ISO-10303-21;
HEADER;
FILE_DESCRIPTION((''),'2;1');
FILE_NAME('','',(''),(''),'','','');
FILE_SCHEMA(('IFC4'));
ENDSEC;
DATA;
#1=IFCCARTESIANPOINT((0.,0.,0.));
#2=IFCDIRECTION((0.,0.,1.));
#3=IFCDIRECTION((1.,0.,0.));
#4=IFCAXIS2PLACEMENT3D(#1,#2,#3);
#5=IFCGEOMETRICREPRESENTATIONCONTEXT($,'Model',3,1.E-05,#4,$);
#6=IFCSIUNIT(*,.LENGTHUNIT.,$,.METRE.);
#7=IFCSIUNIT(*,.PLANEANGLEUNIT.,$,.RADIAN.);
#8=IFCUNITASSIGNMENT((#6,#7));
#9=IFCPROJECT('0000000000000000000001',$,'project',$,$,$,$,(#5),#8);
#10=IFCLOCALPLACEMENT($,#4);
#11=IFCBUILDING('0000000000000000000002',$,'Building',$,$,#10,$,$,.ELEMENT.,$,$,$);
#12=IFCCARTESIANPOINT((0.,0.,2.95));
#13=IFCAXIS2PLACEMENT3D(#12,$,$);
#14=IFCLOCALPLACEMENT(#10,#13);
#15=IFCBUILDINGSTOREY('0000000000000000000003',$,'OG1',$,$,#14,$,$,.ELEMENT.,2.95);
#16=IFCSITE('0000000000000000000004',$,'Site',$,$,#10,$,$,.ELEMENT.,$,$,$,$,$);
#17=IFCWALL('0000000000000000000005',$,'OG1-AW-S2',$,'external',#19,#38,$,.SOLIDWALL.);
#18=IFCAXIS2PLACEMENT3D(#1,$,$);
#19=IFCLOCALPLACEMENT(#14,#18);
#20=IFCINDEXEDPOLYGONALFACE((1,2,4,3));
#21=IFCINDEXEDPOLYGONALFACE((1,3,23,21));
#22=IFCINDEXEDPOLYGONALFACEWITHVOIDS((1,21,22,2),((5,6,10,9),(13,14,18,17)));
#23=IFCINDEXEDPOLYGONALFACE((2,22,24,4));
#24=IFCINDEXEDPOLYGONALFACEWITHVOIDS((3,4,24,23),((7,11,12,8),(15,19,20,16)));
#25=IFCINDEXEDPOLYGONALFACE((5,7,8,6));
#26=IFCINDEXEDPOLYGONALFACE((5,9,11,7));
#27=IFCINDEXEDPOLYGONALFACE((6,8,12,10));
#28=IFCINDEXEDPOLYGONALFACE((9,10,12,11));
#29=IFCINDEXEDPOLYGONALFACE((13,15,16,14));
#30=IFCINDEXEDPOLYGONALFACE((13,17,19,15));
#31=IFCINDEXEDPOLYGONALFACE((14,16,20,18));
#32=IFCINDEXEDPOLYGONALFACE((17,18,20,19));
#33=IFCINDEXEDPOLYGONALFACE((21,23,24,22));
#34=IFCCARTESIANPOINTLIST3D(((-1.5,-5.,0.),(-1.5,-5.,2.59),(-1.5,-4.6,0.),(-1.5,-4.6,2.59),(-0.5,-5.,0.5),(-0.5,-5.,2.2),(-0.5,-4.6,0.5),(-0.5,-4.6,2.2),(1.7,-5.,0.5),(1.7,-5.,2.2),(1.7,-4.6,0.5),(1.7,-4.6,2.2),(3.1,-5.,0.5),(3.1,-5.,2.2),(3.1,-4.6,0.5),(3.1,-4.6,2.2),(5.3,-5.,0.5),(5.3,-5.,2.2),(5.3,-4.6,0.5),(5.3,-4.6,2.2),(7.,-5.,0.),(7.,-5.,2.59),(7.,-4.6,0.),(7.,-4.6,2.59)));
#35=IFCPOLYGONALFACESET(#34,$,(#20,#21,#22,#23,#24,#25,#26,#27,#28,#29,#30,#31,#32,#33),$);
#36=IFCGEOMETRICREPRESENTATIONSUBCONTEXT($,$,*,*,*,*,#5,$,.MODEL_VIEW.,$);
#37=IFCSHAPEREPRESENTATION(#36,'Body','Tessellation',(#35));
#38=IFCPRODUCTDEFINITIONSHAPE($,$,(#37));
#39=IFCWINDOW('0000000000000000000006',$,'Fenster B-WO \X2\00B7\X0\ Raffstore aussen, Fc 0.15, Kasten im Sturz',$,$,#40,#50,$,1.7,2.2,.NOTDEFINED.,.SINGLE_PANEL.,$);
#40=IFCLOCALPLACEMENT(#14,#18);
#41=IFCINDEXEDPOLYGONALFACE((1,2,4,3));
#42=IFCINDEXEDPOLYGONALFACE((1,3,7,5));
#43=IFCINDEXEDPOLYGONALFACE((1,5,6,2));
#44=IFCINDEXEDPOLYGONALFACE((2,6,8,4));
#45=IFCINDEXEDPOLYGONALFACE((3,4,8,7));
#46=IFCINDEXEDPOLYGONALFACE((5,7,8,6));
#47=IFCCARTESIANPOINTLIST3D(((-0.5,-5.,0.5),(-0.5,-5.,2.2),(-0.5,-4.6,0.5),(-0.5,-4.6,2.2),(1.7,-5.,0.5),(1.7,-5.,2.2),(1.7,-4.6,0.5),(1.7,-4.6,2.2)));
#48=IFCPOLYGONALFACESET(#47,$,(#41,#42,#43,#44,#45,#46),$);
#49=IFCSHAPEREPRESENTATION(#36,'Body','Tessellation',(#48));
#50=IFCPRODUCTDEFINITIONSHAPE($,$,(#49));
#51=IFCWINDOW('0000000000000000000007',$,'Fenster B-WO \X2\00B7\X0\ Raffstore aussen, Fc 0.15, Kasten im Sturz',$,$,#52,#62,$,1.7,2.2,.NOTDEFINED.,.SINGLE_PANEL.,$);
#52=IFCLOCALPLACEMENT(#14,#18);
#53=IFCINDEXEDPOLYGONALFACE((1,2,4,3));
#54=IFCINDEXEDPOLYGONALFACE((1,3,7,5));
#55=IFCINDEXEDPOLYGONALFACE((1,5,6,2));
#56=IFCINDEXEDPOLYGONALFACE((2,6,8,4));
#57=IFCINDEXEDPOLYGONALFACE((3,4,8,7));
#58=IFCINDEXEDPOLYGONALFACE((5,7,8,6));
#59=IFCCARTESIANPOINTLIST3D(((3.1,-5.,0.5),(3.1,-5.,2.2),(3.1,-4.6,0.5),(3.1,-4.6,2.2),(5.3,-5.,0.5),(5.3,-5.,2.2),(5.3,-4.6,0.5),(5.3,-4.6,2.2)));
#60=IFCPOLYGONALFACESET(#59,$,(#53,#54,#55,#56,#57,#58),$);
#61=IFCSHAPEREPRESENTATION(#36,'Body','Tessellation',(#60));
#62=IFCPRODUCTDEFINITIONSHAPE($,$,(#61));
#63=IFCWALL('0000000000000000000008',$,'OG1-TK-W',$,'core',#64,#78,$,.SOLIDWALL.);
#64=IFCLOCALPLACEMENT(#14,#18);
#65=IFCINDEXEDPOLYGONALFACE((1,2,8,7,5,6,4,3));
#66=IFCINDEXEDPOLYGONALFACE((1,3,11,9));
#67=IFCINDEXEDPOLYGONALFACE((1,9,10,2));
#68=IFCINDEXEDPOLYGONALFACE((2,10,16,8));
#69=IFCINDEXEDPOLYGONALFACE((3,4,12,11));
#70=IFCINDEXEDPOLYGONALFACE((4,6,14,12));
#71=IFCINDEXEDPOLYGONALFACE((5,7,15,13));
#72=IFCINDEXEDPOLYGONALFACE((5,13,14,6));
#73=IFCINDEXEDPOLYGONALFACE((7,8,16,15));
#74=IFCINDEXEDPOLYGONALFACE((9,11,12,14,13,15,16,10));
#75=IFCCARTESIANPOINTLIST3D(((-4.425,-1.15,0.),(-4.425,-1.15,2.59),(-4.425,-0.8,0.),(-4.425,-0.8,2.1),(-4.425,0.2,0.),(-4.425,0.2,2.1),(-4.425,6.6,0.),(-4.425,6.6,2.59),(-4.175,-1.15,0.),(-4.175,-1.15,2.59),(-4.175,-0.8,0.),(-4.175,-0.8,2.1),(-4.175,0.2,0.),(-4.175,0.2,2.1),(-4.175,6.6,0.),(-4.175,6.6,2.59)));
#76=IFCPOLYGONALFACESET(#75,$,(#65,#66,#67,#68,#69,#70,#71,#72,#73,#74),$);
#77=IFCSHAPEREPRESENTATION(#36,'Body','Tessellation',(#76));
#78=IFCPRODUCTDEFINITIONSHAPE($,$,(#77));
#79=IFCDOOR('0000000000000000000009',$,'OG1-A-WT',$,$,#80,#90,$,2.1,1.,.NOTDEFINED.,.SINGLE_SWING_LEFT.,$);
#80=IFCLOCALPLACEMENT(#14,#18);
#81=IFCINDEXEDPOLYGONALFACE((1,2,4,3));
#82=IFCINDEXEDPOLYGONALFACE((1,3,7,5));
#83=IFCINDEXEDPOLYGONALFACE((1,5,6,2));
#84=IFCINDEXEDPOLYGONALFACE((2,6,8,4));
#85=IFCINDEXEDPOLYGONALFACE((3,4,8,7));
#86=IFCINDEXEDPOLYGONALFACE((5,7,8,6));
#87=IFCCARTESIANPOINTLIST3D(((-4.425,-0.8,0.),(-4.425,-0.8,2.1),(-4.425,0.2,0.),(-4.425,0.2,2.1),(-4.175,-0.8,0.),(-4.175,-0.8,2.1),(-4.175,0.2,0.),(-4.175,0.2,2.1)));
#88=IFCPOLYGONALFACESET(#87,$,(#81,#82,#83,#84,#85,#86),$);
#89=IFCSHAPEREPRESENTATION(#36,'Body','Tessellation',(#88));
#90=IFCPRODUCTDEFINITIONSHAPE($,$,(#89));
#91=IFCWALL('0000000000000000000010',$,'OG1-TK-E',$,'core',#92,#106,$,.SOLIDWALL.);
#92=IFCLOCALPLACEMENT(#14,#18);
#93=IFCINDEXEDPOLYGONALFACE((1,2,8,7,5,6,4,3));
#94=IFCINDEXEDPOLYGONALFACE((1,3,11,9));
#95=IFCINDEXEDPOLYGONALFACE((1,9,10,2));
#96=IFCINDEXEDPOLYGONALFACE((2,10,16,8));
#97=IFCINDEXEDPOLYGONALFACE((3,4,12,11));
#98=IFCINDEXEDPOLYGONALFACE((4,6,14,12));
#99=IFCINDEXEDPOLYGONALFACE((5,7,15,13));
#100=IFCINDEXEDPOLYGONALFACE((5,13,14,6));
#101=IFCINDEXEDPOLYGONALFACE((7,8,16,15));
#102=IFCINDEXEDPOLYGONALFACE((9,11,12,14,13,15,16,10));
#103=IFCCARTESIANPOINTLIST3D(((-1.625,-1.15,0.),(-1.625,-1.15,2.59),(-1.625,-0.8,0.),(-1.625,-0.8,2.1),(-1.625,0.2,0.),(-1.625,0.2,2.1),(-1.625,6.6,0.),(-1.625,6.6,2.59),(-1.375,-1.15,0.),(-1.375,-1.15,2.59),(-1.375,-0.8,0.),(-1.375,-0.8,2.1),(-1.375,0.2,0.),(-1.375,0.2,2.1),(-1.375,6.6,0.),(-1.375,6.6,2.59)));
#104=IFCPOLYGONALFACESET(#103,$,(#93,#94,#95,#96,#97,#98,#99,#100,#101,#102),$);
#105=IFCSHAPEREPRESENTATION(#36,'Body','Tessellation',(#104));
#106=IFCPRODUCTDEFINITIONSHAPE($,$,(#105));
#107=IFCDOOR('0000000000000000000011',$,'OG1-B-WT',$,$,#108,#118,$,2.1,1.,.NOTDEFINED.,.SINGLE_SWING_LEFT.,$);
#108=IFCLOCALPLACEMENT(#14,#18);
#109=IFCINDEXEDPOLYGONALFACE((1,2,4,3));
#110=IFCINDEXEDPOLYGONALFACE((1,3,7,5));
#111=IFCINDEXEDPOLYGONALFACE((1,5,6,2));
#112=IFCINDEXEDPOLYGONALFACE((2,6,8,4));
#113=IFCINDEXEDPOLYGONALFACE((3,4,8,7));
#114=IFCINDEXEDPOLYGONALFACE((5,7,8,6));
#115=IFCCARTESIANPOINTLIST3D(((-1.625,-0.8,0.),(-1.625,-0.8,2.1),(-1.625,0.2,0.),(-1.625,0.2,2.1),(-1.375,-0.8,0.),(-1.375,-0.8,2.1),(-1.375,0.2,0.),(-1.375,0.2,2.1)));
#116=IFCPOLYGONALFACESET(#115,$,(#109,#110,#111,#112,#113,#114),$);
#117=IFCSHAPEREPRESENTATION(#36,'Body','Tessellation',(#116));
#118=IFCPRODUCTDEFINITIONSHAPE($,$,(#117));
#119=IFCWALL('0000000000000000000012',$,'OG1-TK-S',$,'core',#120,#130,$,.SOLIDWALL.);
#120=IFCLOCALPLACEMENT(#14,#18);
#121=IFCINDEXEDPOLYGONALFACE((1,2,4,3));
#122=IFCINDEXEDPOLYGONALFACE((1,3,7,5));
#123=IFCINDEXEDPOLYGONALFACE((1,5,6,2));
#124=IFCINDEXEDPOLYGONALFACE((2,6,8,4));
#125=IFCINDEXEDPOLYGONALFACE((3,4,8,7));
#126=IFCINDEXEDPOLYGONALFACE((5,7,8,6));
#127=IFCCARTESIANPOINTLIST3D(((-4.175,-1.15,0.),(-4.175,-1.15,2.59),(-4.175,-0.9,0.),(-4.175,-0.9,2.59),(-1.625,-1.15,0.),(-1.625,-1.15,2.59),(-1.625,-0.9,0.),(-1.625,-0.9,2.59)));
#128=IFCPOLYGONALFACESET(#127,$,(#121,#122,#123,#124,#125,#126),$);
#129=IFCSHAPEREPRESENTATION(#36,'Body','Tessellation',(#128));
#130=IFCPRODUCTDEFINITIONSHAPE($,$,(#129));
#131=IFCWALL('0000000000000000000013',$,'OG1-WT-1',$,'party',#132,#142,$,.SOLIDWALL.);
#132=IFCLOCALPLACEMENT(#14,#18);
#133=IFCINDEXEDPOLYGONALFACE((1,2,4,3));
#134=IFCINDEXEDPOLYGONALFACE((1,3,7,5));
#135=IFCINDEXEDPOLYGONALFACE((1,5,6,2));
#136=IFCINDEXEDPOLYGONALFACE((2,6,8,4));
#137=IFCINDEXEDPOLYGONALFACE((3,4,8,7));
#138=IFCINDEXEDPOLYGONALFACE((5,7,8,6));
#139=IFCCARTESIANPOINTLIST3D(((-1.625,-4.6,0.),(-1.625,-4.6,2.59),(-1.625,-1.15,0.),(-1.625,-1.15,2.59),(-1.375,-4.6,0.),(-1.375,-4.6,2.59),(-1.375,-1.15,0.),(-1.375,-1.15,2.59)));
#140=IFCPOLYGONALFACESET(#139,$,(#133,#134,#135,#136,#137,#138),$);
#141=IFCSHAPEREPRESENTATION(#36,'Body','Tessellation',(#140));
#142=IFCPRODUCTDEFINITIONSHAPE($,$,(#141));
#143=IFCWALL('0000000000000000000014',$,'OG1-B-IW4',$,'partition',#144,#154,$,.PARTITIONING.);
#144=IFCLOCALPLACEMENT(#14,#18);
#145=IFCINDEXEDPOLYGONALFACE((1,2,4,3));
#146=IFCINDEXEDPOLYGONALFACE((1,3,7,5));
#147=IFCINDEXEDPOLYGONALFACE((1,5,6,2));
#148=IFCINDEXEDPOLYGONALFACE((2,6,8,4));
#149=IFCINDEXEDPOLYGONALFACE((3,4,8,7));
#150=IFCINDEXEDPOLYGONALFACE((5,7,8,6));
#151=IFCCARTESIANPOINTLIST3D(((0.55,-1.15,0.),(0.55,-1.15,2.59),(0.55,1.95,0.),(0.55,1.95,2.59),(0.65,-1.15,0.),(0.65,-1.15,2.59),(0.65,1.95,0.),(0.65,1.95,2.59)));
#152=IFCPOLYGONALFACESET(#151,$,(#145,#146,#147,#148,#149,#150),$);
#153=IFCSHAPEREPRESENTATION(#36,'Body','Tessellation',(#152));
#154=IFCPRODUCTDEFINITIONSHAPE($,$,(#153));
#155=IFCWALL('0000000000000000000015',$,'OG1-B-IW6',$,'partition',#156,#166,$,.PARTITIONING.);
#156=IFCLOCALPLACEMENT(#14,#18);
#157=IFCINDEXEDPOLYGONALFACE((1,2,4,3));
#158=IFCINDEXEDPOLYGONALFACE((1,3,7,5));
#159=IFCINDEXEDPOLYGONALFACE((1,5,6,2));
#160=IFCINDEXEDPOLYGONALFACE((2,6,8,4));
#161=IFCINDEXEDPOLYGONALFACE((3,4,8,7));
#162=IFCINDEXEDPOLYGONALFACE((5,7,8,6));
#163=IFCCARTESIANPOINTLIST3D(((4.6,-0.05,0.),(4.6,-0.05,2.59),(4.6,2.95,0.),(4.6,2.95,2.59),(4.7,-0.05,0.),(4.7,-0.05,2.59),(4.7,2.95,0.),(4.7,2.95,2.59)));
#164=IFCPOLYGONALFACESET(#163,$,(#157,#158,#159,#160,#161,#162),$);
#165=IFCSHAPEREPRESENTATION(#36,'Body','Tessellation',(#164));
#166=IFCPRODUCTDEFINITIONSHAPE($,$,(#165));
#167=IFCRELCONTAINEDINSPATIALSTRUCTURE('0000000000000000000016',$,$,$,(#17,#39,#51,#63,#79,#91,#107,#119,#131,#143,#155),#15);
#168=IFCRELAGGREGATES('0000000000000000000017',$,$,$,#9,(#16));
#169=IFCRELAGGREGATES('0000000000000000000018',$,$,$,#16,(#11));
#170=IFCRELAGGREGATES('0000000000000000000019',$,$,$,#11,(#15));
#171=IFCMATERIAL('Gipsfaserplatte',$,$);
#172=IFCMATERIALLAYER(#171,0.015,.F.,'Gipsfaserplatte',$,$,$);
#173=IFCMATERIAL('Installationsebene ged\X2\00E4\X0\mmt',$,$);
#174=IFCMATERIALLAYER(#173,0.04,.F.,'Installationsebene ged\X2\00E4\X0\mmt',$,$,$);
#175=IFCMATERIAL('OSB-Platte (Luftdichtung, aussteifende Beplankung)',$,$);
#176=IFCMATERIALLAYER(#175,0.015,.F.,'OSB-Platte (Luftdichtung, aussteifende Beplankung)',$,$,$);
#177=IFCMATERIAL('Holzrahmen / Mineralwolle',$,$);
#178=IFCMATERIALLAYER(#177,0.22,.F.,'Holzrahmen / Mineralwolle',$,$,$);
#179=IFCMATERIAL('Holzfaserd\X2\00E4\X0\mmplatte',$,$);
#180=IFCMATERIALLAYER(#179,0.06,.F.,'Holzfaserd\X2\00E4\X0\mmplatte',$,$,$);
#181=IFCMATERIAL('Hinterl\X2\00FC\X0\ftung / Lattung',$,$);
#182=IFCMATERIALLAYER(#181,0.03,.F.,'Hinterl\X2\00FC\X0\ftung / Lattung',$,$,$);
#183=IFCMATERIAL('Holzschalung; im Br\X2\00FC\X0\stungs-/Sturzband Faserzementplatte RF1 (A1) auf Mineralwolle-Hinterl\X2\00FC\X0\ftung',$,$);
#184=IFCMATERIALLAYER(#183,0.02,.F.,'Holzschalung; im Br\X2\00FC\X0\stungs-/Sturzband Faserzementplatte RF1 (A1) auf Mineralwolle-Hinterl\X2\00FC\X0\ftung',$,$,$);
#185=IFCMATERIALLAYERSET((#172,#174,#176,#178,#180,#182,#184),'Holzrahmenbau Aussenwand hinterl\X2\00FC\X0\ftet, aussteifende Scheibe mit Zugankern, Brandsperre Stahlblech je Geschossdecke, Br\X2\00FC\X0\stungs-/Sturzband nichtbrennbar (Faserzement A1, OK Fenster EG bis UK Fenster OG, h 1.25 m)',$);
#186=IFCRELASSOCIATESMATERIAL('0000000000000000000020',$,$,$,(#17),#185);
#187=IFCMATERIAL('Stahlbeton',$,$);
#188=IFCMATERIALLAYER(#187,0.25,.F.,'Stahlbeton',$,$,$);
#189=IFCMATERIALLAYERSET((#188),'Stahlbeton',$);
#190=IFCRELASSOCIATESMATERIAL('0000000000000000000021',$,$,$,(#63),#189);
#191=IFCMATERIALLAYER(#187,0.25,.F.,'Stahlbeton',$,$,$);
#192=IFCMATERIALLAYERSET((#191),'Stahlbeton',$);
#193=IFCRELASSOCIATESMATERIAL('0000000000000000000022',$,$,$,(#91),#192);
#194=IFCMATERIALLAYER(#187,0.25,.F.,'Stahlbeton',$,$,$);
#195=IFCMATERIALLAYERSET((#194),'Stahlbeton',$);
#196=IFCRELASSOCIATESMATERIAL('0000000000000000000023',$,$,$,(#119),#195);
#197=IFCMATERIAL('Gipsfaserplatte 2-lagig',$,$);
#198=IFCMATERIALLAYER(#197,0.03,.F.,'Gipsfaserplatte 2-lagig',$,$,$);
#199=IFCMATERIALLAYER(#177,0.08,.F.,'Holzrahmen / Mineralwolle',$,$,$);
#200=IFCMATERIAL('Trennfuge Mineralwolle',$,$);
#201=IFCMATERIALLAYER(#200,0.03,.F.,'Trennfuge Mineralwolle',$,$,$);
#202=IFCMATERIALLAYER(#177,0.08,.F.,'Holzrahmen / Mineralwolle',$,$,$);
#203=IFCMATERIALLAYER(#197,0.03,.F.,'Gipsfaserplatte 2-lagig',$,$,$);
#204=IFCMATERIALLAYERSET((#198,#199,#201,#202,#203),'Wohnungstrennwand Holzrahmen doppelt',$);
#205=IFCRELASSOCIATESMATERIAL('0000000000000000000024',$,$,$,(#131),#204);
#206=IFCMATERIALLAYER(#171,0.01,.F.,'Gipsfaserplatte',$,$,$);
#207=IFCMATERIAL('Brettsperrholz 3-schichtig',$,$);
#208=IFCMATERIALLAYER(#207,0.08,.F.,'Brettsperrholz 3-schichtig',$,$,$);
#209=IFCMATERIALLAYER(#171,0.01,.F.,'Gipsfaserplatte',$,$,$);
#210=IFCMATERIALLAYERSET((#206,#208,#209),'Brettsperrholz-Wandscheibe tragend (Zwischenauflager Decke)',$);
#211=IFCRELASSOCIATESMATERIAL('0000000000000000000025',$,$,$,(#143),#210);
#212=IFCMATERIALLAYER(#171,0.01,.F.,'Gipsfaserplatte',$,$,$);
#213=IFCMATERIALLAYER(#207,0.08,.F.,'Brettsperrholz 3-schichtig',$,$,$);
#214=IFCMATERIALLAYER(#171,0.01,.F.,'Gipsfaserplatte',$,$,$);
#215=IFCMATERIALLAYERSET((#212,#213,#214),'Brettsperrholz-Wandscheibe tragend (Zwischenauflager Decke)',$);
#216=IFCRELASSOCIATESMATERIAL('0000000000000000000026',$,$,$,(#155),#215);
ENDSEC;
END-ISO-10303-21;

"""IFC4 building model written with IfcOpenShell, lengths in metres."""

from ifc_helpers import new_model, si_unit, frame, frame_2d, origin, origin_with_axes, place, context, subcontext, project, spatial, rectangle, extrude, material, layer, layer_set, element, fill, save


model = new_model("IFC4")

# Units and contexts
model_context = context("Model", 3, precision=1e-05, world=origin_with_axes())
sub_context = subcontext(model_context, None, None, "MODEL_VIEW")
ifc_project = project(units=[si_unit("LENGTHUNIT", "METRE"), si_unit("PLANEANGLEUNIT", "RADIAN")], contexts=[model_context])

# Site, building, storey
placement = place(None, origin_with_axes())
site = spatial("IfcSite", under=ifc_project, at=placement, Name="Site", CompositionType="ELEMENT")
building = spatial("IfcBuilding", under=site, at=placement, Name="Building", CompositionType="ELEMENT")
storey_placement = place(placement, frame((0.0, 0.0, 2.95)))
storey = spatial("IfcBuildingStorey", under=building, at=storey_placement, Name="OG1", CompositionType="ELEMENT", Elevation=2.95)

# Wall, openings, windows
ifc_material_1 = material(Name="Gipsfaserplatte")
ifc_layer_1 = layer(ifc_material_1, 0.015, ventilated=False, Name="Gipsfaserplatte")
ifc_material_2 = material(Name="Installationsebene gedämmt")
ifc_layer_2 = layer(ifc_material_2, 0.04, ventilated=False, Name="Installationsebene gedämmt")
ifc_material_3 = material(Name="OSB-Platte (Luftdichtung, aussteifende Beplankung)")
ifc_layer_3 = layer(ifc_material_3, 0.015, ventilated=False, Name="OSB-Platte (Luftdichtung, aussteifende Beplankung)")
ifc_material_4 = material(Name="Holzrahmen / Mineralwolle")
ifc_layer_4 = layer(ifc_material_4, 0.22, ventilated=False, Name="Holzrahmen / Mineralwolle")
ifc_material_5 = material(Name="Holzfaserdämmplatte")
ifc_layer_5 = layer(ifc_material_5, 0.06, ventilated=False, Name="Holzfaserdämmplatte")
ifc_material_6 = material(Name="Hinterlüftung / Lattung")
ifc_layer_6 = layer(ifc_material_6, 0.03, ventilated=False, Name="Hinterlüftung / Lattung")
ifc_material_7 = material(Name="Holzschalung; im Brüstungs-/Sturzband Faserzementplatte RF1 (A1) auf Mineralwolle-Hinterlüftung")
ifc_layer_7 = layer(ifc_material_7, 0.02, ventilated=False, Name="Holzschalung; im Brüstungs-/Sturzband Faserzementplatte RF1 (A1) auf Mineralwolle-Hinterlüftung")
ifc_layer_set_1 = layer_set([ifc_layer_1, ifc_layer_2, ifc_layer_3, ifc_layer_4, ifc_layer_5, ifc_layer_6, ifc_layer_7], Name="Holzrahmenbau Aussenwand hinterlüftet, aussteifende Scheibe mit Zugankern, Brandsperre Stahlblech je Geschossdecke, Brüstungs-/Sturzband nichtbrennbar (Faserzement A1, OK Fenster EG bis UK Fenster OG, h 1.25 m)")
wall_1_placement = place(storey_placement, frame((7.0, -4.8, 0.0), z_axis=(0.0, 0.0, 1.0), x_axis=(-1.0, 0.0, 0.0)))
wall_1 = element("IfcWall", 1, at=wall_1_placement, inside=storey, material=ifc_layer_set_1, Name="OG1-AW-S2", ObjectType="external", PredefinedType="SOLIDWALL", context=sub_context, shape_type="SweptSolid", body=[
    extrude(rectangle(XDim=8.5, YDim=0.4, at=frame_2d((4.25, 0.0))), origin(), (0.0, 0.0, 1.0), 2.59),
])
opening_1_placement = place(wall_1_placement, frame((6.4, 0.25, 0.5), z_axis=(0.0, -1.0, 0.0), x_axis=(1.0, 0.0, 0.0)))
opening_1 = element("IfcOpeningElement", 2, at=opening_1_placement, cuts=wall_1, PredefinedType="OPENING", context=sub_context, shape_type="SweptSolid", body=[
    extrude(rectangle(XDim=2.2, YDim=1.7, at=frame_2d((0.0, 0.85))), origin(), (0.0, 0.0, 1.0), 0.5),
])
opening_2_placement = place(wall_1_placement, frame((2.8, 0.25, 0.5), z_axis=(0.0, -1.0, 0.0), x_axis=(1.0, 0.0, 0.0)))
opening_2 = element("IfcOpeningElement", 3, at=opening_2_placement, cuts=wall_1, PredefinedType="OPENING", context=sub_context, shape_type="SweptSolid", body=[
    extrude(rectangle(XDim=2.2, YDim=1.7, at=frame_2d((0.0, 0.85))), origin(), (0.0, 0.0, 1.0), 0.5),
])
window_1_placement = place(wall_1_placement, frame((6.4, 0.2, 0.5), z_axis=(0.0, -1.0, 0.0), x_axis=(1.0, 0.0, 0.0)))
window_1 = element("IfcWindow", 4, at=window_1_placement, inside=storey, Name="Fenster B-WO · Raffstore aussen, Fc 0.15, Kasten im Sturz", OverallHeight=1.7, OverallWidth=2.2, PartitioningType="SINGLE_PANEL", PredefinedType="NOTDEFINED", context=sub_context, shape_type="SweptSolid", body=[
    extrude(rectangle(XDim=2.2, YDim=1.7, at=frame_2d((0.0, 0.85))), origin(), (0.0, 0.0, 1.0), 0.4),
])
fill(opening_1, window_1)
window_2_placement = place(wall_1_placement, frame((2.8, 0.2, 0.5), z_axis=(0.0, -1.0, 0.0), x_axis=(1.0, 0.0, 0.0)))
window_2 = element("IfcWindow", 5, at=window_2_placement, inside=storey, Name="Fenster B-WO · Raffstore aussen, Fc 0.15, Kasten im Sturz", OverallHeight=1.7, OverallWidth=2.2, PartitioningType="SINGLE_PANEL", PredefinedType="NOTDEFINED", context=sub_context, shape_type="SweptSolid", body=[
    extrude(rectangle(XDim=2.2, YDim=1.7, at=frame_2d((0.0, 0.85))), origin(), (0.0, 0.0, 1.0), 0.4),
])
fill(opening_2, window_2)

# Walls, openings, doors
ifc_material_8 = material(Name="Stahlbeton")
ifc_layer_8 = layer(ifc_material_8, 0.25, ventilated=False, Name="Stahlbeton")
ifc_layer_set_2 = layer_set([ifc_layer_8], Name="Stahlbeton")
wall_2_placement = place(storey_placement, frame((-4.3, -1.15, 0.0), z_axis=(0.0, 0.0, 1.0), x_axis=(0.0, 1.0, 0.0)))
wall_2 = element("IfcWall", 6, at=wall_2_placement, inside=storey, material=ifc_layer_set_2, Name="OG1-TK-W", ObjectType="core", PredefinedType="SOLIDWALL", context=sub_context, shape_type="SweptSolid", body=[
    extrude(rectangle(XDim=7.75, YDim=0.25, at=frame_2d((3.875, 0.0))), origin(), (0.0, 0.0, 1.0), 2.59),
])
opening_3_placement = place(wall_2_placement, frame((0.85, 0.175, 0.0), z_axis=(0.0, -1.0, 0.0), x_axis=(1.0, 0.0, 0.0)))
opening_3 = element("IfcOpeningElement", 7, at=opening_3_placement, cuts=wall_2, PredefinedType="OPENING", context=sub_context, shape_type="SweptSolid", body=[
    extrude(rectangle(XDim=1.0, YDim=2.1, at=frame_2d((0.0, 1.05))), origin(), (0.0, 0.0, 1.0), 0.35),
])
door_1_placement = place(wall_2_placement, frame((0.85, 0.125, 0.0), z_axis=(0.0, -1.0, 0.0), x_axis=(1.0, 0.0, 0.0)))
door_1 = element("IfcDoor", 8, at=door_1_placement, inside=storey, Name="OG1-A-WT", OperationType="SINGLE_SWING_LEFT", OverallHeight=2.1, OverallWidth=1.0, PredefinedType="NOTDEFINED", context=sub_context, shape_type="SweptSolid", body=[
    extrude(rectangle(XDim=1.0, YDim=2.1, at=frame_2d((0.0, 1.05))), origin(), (0.0, 0.0, 1.0), 0.25),
])
fill(opening_3, door_1)
ifc_layer_9 = layer(ifc_material_8, 0.25, ventilated=False, Name="Stahlbeton")
ifc_layer_set_3 = layer_set([ifc_layer_9], Name="Stahlbeton")
wall_3_placement = place(storey_placement, frame((-1.5, -1.15, 0.0), z_axis=(0.0, 0.0, 1.0), x_axis=(0.0, 1.0, 0.0)))
wall_3 = element("IfcWall", 9, at=wall_3_placement, inside=storey, material=ifc_layer_set_3, Name="OG1-TK-E", ObjectType="core", PredefinedType="SOLIDWALL", context=sub_context, shape_type="SweptSolid", body=[
    extrude(rectangle(XDim=7.75, YDim=0.25, at=frame_2d((3.875, 0.0))), origin(), (0.0, 0.0, 1.0), 2.59),
])
opening_4_placement = place(wall_3_placement, frame((0.85, 0.175, 0.0), z_axis=(0.0, -1.0, 0.0), x_axis=(1.0, 0.0, 0.0)))
opening_4 = element("IfcOpeningElement", 10, at=opening_4_placement, cuts=wall_3, PredefinedType="OPENING", context=sub_context, shape_type="SweptSolid", body=[
    extrude(rectangle(XDim=1.0, YDim=2.1, at=frame_2d((0.0, 1.05))), origin(), (0.0, 0.0, 1.0), 0.35),
])
door_2_placement = place(wall_3_placement, frame((0.85, 0.125, 0.0), z_axis=(0.0, -1.0, 0.0), x_axis=(1.0, 0.0, 0.0)))
door_2 = element("IfcDoor", 11, at=door_2_placement, inside=storey, Name="OG1-B-WT", OperationType="SINGLE_SWING_LEFT", OverallHeight=2.1, OverallWidth=1.0, PredefinedType="NOTDEFINED", context=sub_context, shape_type="SweptSolid", body=[
    extrude(rectangle(XDim=1.0, YDim=2.1, at=frame_2d((0.0, 1.05))), origin(), (0.0, 0.0, 1.0), 0.25),
])
fill(opening_4, door_2)

# Walls
ifc_layer_10 = layer(ifc_material_8, 0.25, ventilated=False, Name="Stahlbeton")
ifc_layer_set_4 = layer_set([ifc_layer_10], Name="Stahlbeton")
wall_4_placement = place(storey_placement, frame((-4.175, -1.025, 0.0), z_axis=(0.0, 0.0, 1.0), x_axis=(1.0, 0.0, 0.0)))
element("IfcWall", 12, at=wall_4_placement, inside=storey, material=ifc_layer_set_4, Name="OG1-TK-S", ObjectType="core", PredefinedType="SOLIDWALL", context=sub_context, shape_type="SweptSolid", body=[
    extrude(rectangle(XDim=2.55, YDim=0.25, at=frame_2d((1.275, 0.0))), origin(), (0.0, 0.0, 1.0), 2.59),
])
ifc_material_9 = material(Name="Gipsfaserplatte 2-lagig")
ifc_layer_11 = layer(ifc_material_9, 0.03, ventilated=False, Name="Gipsfaserplatte 2-lagig")
ifc_layer_12 = layer(ifc_material_4, 0.08, ventilated=False, Name="Holzrahmen / Mineralwolle")
ifc_material_10 = material(Name="Trennfuge Mineralwolle")
ifc_layer_13 = layer(ifc_material_10, 0.03, ventilated=False, Name="Trennfuge Mineralwolle")
ifc_layer_14 = layer(ifc_material_4, 0.08, ventilated=False, Name="Holzrahmen / Mineralwolle")
ifc_layer_15 = layer(ifc_material_9, 0.03, ventilated=False, Name="Gipsfaserplatte 2-lagig")
ifc_layer_set_5 = layer_set([ifc_layer_11, ifc_layer_12, ifc_layer_13, ifc_layer_14, ifc_layer_15], Name="Wohnungstrennwand Holzrahmen doppelt")
wall_5_placement = place(storey_placement, frame((-1.5, -1.15, 0.0), z_axis=(0.0, 0.0, 1.0), x_axis=(0.0, -1.0, 0.0)))
element("IfcWall", 13, at=wall_5_placement, inside=storey, material=ifc_layer_set_5, Name="OG1-WT-1", ObjectType="party", PredefinedType="SOLIDWALL", context=sub_context, shape_type="SweptSolid", body=[
    extrude(rectangle(XDim=3.45, YDim=0.25, at=frame_2d((1.725, 0.0))), origin(), (0.0, 0.0, 1.0), 2.59),
])
ifc_layer_16 = layer(ifc_material_1, 0.01, ventilated=False, Name="Gipsfaserplatte")
ifc_material_11 = material(Name="Brettsperrholz 3-schichtig")
ifc_layer_17 = layer(ifc_material_11, 0.08, ventilated=False, Name="Brettsperrholz 3-schichtig")
ifc_layer_18 = layer(ifc_material_1, 0.01, ventilated=False, Name="Gipsfaserplatte")
ifc_layer_set_6 = layer_set([ifc_layer_16, ifc_layer_17, ifc_layer_18], Name="Brettsperrholz-Wandscheibe tragend (Zwischenauflager Decke)")
wall_6_placement = place(storey_placement, frame((0.6, -1.15, 0.0), z_axis=(0.0, 0.0, 1.0), x_axis=(0.0, 1.0, 0.0)))
element("IfcWall", 14, at=wall_6_placement, inside=storey, material=ifc_layer_set_6, Name="OG1-B-IW4", ObjectType="partition", PredefinedType="PARTITIONING", context=sub_context, shape_type="SweptSolid", body=[
    extrude(rectangle(XDim=3.1, YDim=0.1, at=frame_2d((1.55, 0.0))), origin(), (0.0, 0.0, 1.0), 2.59),
])
ifc_layer_19 = layer(ifc_material_1, 0.01, ventilated=False, Name="Gipsfaserplatte")
ifc_layer_20 = layer(ifc_material_11, 0.08, ventilated=False, Name="Brettsperrholz 3-schichtig")
ifc_layer_21 = layer(ifc_material_1, 0.01, ventilated=False, Name="Gipsfaserplatte")
ifc_layer_set_7 = layer_set([ifc_layer_19, ifc_layer_20, ifc_layer_21], Name="Brettsperrholz-Wandscheibe tragend (Zwischenauflager Decke)")
wall_7_placement = place(storey_placement, frame((4.65, -0.05, 0.0), z_axis=(0.0, 0.0, 1.0), x_axis=(0.0, 1.0, 0.0)))
element("IfcWall", 15, at=wall_7_placement, inside=storey, material=ifc_layer_set_7, Name="OG1-B-IW6", ObjectType="partition", PredefinedType="PARTITIONING", context=sub_context, shape_type="SweptSolid", body=[
    extrude(rectangle(XDim=3.0, YDim=0.1, at=frame_2d((1.5, 0.0))), origin(), (0.0, 0.0, 1.0), 2.59),
])

save(model, "model.ifc")
